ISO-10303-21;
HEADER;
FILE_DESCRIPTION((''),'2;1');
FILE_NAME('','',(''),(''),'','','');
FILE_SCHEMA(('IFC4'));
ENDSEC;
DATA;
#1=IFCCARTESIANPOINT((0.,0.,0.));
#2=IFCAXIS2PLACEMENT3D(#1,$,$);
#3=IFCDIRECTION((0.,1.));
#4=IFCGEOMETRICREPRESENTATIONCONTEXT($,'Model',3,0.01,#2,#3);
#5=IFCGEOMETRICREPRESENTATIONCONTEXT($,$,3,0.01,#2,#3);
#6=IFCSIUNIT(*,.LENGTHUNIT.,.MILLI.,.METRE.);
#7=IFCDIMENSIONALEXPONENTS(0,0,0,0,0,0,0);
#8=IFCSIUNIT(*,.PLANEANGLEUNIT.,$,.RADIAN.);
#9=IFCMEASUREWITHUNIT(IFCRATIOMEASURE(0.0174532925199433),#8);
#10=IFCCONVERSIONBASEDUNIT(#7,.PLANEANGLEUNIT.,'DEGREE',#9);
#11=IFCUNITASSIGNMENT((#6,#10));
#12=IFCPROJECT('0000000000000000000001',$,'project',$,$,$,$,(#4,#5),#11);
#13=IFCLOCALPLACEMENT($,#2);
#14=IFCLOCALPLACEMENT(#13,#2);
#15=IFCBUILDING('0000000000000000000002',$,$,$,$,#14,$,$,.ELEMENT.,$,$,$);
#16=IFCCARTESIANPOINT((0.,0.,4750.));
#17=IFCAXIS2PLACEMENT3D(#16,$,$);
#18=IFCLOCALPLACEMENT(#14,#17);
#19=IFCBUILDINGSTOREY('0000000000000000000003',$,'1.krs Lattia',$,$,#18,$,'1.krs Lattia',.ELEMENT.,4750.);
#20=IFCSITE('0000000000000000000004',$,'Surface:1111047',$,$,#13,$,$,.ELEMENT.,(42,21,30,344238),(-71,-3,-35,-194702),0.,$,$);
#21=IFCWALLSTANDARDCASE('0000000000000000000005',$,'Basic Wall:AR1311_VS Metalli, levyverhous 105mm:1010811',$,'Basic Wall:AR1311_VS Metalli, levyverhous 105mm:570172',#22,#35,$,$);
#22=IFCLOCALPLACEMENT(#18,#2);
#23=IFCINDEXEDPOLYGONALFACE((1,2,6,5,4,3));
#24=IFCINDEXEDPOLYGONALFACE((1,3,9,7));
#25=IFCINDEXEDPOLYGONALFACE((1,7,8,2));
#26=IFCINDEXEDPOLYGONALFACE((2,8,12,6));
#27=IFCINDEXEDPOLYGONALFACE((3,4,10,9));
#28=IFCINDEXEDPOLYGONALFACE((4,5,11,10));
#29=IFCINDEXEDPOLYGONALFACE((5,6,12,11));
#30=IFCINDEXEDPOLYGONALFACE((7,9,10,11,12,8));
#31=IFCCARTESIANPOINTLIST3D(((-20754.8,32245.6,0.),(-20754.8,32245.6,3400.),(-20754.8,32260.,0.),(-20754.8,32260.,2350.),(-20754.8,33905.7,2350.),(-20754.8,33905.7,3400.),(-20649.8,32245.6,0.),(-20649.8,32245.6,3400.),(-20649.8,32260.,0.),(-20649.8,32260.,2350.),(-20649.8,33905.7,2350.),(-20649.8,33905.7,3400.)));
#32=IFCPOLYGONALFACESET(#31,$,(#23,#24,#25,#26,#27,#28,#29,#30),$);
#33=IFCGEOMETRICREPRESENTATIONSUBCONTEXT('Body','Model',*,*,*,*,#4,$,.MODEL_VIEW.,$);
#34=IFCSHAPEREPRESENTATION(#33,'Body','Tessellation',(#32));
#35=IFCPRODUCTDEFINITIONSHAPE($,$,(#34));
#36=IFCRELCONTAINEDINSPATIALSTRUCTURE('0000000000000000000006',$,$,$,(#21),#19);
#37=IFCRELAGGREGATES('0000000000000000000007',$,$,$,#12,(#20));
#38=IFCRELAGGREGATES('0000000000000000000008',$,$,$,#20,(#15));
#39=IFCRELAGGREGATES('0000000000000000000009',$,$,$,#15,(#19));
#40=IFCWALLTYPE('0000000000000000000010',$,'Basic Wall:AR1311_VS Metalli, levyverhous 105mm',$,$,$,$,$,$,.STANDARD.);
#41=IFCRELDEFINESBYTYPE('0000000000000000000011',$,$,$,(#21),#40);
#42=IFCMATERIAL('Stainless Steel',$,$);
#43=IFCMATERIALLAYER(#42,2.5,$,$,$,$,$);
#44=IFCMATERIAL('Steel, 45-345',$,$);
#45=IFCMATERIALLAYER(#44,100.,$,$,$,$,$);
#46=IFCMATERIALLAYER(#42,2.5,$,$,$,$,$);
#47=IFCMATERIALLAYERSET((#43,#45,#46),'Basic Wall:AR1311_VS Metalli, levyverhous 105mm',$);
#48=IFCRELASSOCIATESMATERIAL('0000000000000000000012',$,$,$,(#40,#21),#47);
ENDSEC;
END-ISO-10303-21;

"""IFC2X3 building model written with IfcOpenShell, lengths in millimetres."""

from ifc_helpers import new_model, entity, si_unit, converted_unit, direction, frame, frame_2d, origin, place, context, subcontext, project, spatial, rectangle, extrude, material, layer, layer_set, layer_usage, type_object, element, save


model = new_model("IFC2X3")

# Units and contexts
model_context = context("Model", 3, precision=0.01, world=origin(), true_north=direction((0.0, 1.0)))
context_of_model = context(None, 3, precision=0.01, world=origin(), true_north=direction((0.0, 1.0)))
body_context = subcontext(model_context, "Body", "Model", "MODEL_VIEW")
ifc_project = project(units=[si_unit("LENGTHUNIT", "METRE", prefix="MILLI"), converted_unit("PLANEANGLEUNIT", "DEGREE", entity("IfcRatioMeasure", 0.0174532925199433), si_unit("PLANEANGLEUNIT", "RADIAN"), dimensions=[0, 0, 0, 0, 0, 0, 0])], contexts=[model_context, context_of_model])

# Site, building, storey
site_placement = place(None, origin())
site = spatial("IfcSite", under=ifc_project, at=site_placement, Name="Surface:1111047", CompositionType="ELEMENT", RefLatitude=(42, 21, 30, 344238), RefLongitude=(-71, -3, -35, -194702), RefElevation=0.0)
building_placement = place(site_placement, origin())
building = spatial("IfcBuilding", under=site, at=building_placement, CompositionType="ELEMENT")
storey_placement = place(building_placement, frame((0.0, 0.0, 4750.0)))
storey = spatial("IfcBuildingStorey", under=building, at=storey_placement, Name="1.krs Lattia", LongName="1.krs Lattia", CompositionType="ELEMENT", Elevation=4750.0)

# Wall, opening
ifc_material_1 = material(Name="Stainless Steel")
ifc_layer_1 = layer(ifc_material_1, 2.5)
ifc_material_2 = material(Name="Steel, 45-345")
ifc_layer_2 = layer(ifc_material_2, 100.0)
ifc_layer_3 = layer(ifc_material_1, 2.5)
ifc_layer_set_1 = layer_set([ifc_layer_1, ifc_layer_2, ifc_layer_3], Name="Basic Wall:AR1311_VS Metalli, levyverhous 105mm")
ifc_layer_usage_1 = layer_usage(ifc_layer_set_1, "AXIS2", "NEGATIVE", 52.5)
wall_type_1 = type_object("IfcWallType", Name="Basic Wall:AR1311_VS Metalli, levyverhous 105mm", PredefinedType="STANDARD", material=ifc_layer_set_1)
wall_1_placement = place(storey_placement, frame((-20702.3, 33905.7, 0.0), z_axis=(0.0, 0.0, 1.0), x_axis=(0.0, -1.0, 0.0)))
wall_1 = element("IfcWallStandardCase", 1, at=wall_1_placement, inside=storey, type_object=wall_type_1, material=ifc_layer_usage_1, Name="Basic Wall:AR1311_VS Metalli, levyverhous 105mm:1010811", ObjectType="Basic Wall:AR1311_VS Metalli, levyverhous 105mm:570172", context=body_context, shape_type="SweptSolid", body=[
    extrude(rectangle(XDim=1660.1, YDim=105.0, at=frame_2d((830.1, 0.0), x_axis=(-1.0, 0.0))), origin(), (0.0, 0.0, 1.0), 3400.0),
])
opening_1_placement = place(wall_1_placement, frame((-54.3, -52.5, 0.0)))
element("IfcOpeningElement", 2, at=opening_1_placement, cuts=wall_1, ObjectType="Opening", context=body_context, shape_type="SweptSolid", body=[
    extrude(rectangle(XDim=2350.0, YDim=1700.0, at=frame_2d((1175.0, 850.0), x_axis=(1.0, 0.0))), frame((0.0, 0.0, 0.0), z_axis=(0.0, 1.0, 0.0), x_axis=(0.0, 0.0, 1.0)), (0.0, 0.0, 1.0), 105.0),
])

save(model, "model.ifc")
